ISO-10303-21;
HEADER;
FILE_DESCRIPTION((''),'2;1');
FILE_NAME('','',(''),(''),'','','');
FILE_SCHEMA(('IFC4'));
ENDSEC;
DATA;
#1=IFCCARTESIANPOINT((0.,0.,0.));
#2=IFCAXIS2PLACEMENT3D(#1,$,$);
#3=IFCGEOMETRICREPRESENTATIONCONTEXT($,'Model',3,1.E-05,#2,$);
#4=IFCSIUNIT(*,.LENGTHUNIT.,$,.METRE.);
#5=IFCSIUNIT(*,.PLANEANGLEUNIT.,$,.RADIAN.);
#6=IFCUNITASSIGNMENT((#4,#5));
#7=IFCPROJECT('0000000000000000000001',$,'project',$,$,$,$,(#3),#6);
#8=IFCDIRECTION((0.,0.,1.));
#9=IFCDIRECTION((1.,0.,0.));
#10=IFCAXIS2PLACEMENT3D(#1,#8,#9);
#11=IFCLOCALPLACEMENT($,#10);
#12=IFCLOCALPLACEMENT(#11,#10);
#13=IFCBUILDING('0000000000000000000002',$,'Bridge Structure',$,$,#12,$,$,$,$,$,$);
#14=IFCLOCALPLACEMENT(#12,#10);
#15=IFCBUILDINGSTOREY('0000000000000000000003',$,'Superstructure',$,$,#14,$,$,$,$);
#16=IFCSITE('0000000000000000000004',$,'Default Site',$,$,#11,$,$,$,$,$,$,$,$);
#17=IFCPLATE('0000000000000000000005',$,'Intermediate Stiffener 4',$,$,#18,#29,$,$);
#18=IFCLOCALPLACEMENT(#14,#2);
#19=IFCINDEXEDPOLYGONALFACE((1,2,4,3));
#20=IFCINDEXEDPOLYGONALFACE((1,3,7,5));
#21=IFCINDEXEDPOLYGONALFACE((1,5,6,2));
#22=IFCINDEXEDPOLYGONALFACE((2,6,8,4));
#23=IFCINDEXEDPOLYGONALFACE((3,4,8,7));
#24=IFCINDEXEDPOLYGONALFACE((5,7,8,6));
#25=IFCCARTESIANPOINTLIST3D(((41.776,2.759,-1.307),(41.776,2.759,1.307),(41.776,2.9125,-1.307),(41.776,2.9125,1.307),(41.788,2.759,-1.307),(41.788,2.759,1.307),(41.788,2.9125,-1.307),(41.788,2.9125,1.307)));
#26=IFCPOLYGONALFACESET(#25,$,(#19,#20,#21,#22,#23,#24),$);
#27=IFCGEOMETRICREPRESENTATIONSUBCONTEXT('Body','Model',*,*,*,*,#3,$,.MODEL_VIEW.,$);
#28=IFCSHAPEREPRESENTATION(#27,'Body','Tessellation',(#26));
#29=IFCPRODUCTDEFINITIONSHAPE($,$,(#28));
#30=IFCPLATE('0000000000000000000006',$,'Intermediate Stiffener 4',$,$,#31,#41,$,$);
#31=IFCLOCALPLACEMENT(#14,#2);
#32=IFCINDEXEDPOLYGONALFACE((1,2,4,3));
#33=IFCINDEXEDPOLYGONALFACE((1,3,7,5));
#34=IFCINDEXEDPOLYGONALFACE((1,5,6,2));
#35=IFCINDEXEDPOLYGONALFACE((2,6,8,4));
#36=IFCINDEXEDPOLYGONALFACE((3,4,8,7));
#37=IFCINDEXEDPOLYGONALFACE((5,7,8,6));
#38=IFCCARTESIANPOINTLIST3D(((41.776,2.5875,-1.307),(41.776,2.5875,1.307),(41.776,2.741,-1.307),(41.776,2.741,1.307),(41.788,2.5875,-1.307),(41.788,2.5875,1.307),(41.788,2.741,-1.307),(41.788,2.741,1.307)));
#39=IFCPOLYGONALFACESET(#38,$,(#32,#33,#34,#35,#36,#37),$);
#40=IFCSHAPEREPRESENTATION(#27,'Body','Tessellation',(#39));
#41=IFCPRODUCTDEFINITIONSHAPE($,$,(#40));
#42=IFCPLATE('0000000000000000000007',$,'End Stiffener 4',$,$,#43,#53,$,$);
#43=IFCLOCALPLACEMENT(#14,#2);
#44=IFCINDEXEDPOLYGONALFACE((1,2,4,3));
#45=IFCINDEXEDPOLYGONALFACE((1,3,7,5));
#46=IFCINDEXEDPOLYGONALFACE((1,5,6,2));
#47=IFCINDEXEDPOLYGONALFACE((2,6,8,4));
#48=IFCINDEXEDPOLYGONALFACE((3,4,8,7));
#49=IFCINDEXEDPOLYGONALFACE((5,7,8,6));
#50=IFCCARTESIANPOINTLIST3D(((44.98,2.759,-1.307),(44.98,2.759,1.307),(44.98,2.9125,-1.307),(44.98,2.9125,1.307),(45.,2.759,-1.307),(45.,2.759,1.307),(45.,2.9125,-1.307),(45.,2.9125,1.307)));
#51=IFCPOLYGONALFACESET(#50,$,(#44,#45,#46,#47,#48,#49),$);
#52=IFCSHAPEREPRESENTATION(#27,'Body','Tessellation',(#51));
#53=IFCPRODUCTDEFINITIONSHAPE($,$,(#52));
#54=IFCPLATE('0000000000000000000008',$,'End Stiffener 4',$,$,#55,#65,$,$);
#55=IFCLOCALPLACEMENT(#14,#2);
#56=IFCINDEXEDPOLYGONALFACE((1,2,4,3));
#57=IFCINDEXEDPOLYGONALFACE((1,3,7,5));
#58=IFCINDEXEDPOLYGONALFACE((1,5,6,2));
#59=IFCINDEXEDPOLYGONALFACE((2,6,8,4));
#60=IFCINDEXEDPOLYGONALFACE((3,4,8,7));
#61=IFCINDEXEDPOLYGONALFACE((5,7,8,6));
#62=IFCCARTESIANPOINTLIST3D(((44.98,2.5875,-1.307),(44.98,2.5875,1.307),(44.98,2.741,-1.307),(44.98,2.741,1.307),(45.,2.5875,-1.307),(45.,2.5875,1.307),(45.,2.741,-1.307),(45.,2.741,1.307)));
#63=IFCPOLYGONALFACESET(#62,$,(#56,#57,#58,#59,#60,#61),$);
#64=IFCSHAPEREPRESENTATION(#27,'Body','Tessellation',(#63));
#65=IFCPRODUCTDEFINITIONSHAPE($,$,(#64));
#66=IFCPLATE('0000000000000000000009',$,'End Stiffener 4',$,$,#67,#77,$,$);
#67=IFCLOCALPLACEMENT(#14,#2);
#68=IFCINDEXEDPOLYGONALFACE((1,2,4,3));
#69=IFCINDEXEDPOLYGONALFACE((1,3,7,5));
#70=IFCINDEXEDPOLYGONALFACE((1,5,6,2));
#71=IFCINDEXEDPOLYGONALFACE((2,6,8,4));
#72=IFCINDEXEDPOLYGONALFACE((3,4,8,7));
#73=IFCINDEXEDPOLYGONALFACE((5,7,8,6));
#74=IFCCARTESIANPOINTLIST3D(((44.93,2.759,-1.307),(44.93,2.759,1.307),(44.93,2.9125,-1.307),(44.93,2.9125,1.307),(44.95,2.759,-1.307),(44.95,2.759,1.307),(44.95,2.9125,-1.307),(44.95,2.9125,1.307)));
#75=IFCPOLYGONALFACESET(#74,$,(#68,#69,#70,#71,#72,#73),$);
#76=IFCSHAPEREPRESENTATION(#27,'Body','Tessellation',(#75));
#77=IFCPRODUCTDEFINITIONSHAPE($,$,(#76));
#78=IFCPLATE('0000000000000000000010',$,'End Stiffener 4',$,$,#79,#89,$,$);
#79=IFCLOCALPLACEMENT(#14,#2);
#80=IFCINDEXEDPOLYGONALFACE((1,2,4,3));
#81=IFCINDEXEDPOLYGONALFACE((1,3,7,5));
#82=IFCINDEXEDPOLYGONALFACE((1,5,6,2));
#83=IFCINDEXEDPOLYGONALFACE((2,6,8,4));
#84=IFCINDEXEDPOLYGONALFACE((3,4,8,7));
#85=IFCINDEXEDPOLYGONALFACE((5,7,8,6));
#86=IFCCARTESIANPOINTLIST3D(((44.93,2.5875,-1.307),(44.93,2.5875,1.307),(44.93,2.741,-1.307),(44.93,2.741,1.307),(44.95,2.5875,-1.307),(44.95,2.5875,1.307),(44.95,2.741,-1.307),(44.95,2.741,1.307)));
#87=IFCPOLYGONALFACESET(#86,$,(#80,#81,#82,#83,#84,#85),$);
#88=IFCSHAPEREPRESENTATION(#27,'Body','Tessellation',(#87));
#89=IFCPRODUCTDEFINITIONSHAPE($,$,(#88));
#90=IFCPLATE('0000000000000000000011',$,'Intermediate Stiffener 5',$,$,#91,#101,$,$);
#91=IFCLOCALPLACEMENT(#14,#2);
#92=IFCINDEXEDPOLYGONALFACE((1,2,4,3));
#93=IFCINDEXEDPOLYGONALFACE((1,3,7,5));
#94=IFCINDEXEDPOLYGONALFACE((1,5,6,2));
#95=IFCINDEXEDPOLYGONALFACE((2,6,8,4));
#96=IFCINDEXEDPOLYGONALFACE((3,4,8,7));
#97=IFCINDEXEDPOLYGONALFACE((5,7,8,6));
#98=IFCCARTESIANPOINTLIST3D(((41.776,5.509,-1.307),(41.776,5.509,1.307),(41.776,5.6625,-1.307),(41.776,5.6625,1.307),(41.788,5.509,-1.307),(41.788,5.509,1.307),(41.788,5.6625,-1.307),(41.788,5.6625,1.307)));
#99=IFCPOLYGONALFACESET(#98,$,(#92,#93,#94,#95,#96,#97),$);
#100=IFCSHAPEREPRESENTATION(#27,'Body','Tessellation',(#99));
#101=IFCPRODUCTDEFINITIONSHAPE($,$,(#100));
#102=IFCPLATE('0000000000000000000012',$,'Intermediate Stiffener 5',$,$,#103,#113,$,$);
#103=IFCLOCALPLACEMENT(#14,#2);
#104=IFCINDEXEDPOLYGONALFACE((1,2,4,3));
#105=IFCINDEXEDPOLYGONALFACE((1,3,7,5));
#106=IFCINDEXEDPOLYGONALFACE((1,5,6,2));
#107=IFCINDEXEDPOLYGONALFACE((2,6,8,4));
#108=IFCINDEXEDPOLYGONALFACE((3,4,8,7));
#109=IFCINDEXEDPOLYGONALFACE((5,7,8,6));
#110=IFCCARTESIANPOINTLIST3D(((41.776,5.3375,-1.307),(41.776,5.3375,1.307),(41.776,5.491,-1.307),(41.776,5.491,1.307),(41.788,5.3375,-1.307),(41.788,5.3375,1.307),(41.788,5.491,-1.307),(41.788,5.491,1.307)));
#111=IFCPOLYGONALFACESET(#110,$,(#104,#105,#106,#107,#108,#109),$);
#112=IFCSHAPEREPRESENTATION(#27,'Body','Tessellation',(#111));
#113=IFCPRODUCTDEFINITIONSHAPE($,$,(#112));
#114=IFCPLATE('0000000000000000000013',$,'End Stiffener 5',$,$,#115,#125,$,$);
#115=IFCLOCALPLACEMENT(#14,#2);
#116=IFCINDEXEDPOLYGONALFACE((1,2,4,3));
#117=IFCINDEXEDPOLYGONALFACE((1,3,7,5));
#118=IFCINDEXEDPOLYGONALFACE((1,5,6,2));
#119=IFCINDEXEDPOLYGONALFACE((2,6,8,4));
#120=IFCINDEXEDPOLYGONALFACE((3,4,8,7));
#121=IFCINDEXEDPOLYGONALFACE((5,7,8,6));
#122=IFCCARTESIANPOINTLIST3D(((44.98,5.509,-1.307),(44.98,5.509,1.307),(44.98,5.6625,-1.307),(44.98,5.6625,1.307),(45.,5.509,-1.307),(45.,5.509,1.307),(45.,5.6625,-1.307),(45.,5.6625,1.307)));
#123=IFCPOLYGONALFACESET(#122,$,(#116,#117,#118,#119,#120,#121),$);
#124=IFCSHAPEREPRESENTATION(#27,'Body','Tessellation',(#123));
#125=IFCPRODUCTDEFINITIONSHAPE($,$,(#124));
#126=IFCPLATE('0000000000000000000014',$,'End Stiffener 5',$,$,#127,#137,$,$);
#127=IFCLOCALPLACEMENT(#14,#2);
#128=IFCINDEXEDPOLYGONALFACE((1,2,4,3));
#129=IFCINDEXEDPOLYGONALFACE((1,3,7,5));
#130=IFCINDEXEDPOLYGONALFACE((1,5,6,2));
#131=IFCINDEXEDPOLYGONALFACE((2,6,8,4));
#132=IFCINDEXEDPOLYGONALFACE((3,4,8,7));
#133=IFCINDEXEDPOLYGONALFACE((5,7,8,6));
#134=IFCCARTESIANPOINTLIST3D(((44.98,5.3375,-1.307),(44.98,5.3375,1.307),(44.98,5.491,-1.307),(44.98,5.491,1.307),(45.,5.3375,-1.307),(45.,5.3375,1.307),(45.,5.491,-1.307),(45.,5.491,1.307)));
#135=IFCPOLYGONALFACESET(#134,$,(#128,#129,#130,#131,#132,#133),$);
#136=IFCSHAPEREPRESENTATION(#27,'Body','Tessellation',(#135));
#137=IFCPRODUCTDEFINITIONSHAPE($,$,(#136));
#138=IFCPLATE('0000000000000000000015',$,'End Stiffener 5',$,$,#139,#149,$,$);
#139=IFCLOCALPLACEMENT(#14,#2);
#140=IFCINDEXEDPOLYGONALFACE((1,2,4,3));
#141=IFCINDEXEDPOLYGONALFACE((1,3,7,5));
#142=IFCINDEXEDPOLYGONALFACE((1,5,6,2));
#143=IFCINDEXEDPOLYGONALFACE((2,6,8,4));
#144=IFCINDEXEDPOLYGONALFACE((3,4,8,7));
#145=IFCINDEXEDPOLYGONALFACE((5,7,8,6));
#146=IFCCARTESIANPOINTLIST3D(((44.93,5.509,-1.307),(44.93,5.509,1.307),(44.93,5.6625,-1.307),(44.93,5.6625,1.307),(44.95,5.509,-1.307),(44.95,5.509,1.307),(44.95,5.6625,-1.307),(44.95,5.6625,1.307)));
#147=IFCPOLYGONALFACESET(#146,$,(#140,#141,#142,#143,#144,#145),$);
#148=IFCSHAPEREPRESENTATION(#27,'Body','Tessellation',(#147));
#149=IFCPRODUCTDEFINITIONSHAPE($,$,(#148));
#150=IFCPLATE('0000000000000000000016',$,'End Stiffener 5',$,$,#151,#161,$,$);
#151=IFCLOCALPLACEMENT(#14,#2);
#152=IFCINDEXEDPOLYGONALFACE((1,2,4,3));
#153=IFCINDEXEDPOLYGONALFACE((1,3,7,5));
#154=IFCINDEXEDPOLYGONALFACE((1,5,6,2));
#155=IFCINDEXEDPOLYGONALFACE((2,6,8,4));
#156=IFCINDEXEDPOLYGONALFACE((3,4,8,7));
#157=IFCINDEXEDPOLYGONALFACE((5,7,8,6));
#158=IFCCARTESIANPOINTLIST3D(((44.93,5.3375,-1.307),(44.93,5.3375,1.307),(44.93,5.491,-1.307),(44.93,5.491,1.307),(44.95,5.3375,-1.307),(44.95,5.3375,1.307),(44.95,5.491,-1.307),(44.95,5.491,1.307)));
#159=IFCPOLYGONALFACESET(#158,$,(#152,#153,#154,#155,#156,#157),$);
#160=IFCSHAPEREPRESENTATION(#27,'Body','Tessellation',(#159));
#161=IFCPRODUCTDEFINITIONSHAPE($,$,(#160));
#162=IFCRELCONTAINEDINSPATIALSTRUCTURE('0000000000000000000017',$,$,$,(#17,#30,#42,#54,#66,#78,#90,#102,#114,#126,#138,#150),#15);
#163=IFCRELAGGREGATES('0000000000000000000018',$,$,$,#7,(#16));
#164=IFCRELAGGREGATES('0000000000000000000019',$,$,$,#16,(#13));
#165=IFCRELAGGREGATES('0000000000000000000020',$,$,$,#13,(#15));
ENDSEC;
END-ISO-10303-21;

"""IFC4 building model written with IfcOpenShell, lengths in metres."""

from ifc_helpers import new_model, si_unit, frame, origin, origin_with_axes, origin_2d_with_axis, place, context, subcontext, project, spatial, rectangle, extrude, element, save


model = new_model("IFC4")

# Units and contexts
model_context = context("Model", 3, precision=1e-05, world=origin())
body_context = subcontext(model_context, "Body", "Model", "MODEL_VIEW")
ifc_project = project(units=[si_unit("LENGTHUNIT", "METRE"), si_unit("PLANEANGLEUNIT", "RADIAN")], contexts=[model_context])

# Site, building, storey
site_placement = place(None, origin_with_axes())
site = spatial("IfcSite", under=ifc_project, at=site_placement, Name="Default Site")
building_placement = place(site_placement, origin_with_axes())
building = spatial("IfcBuilding", under=site, at=building_placement, Name="Bridge Structure")
storey_placement = place(building_placement, origin_with_axes())
storey = spatial("IfcBuildingStorey", under=building, at=storey_placement, Name="Superstructure")

# Plates
for number, where, z_axis, x_axis, name in (
    (1, (41.782, 2.8357, -1.307), (0.0, 0.0, 1.0), (1.0, 0.0, 0.0), "Intermediate Stiffener 4"),
    (2, (41.782, 2.6643, -1.307), (0.0, 0.0, 1.0), (1.0, 0.0, 0.0), "Intermediate Stiffener 4"),
):
    element("IfcPlate", number, at=place(storey_placement, frame(where, z_axis=z_axis, x_axis=x_axis)), inside=storey, Name=name, context=body_context, shape_type="SweptSolid", body=[
        extrude(rectangle(XDim=0.012, YDim=0.1535, at=origin_2d_with_axis()), origin_with_axes(), (0.0, 0.0, 1.0), 2.614),
    ])
for number, where, z_axis, x_axis, name in (
    (3, (44.99, 2.8357, -1.307), (0.0, 0.0, 1.0), (1.0, 0.0, 0.0), "End Stiffener 4"),
    (4, (44.99, 2.6643, -1.307), (0.0, 0.0, 1.0), (1.0, 0.0, 0.0), "End Stiffener 4"),
    (5, (44.94, 2.8357, -1.307), (0.0, 0.0, 1.0), (1.0, 0.0, 0.0), "End Stiffener 4"),
    (6, (44.94, 2.6643, -1.307), (0.0, 0.0, 1.0), (1.0, 0.0, 0.0), "End Stiffener 4"),
):
    element("IfcPlate", number, at=place(storey_placement, frame(where, z_axis=z_axis, x_axis=x_axis)), inside=storey, Name=name, context=body_context, shape_type="SweptSolid", body=[
        extrude(rectangle(XDim=0.02, YDim=0.1535, at=origin_2d_with_axis()), origin_with_axes(), (0.0, 0.0, 1.0), 2.614),
    ])
for number, where, z_axis, x_axis, name in (
    (7, (41.782, 5.5857, -1.307), (0.0, 0.0, 1.0), (1.0, 0.0, 0.0), "Intermediate Stiffener 5"),
    (8, (41.782, 5.4143, -1.307), (0.0, 0.0, 1.0), (1.0, 0.0, 0.0), "Intermediate Stiffener 5"),
):
    element("IfcPlate", number, at=place(storey_placement, frame(where, z_axis=z_axis, x_axis=x_axis)), inside=storey, Name=name, context=body_context, shape_type="SweptSolid", body=[
        extrude(rectangle(XDim=0.012, YDim=0.1535, at=origin_2d_with_axis()), origin_with_axes(), (0.0, 0.0, 1.0), 2.614),
    ])
for number, where, z_axis, x_axis, name in (
    (9, (44.99, 5.5857, -1.307), (0.0, 0.0, 1.0), (1.0, 0.0, 0.0), "End Stiffener 5"),
    (10, (44.99, 5.4143, -1.307), (0.0, 0.0, 1.0), (1.0, 0.0, 0.0), "End Stiffener 5"),
    (11, (44.94, 5.5857, -1.307), (0.0, 0.0, 1.0), (1.0, 0.0, 0.0), "End Stiffener 5"),
    (12, (44.94, 5.4143, -1.307), (0.0, 0.0, 1.0), (1.0, 0.0, 0.0), "End Stiffener 5"),
):
    element("IfcPlate", number, at=place(storey_placement, frame(where, z_axis=z_axis, x_axis=x_axis)), inside=storey, Name=name, context=body_context, shape_type="SweptSolid", body=[
        extrude(rectangle(XDim=0.02, YDim=0.1535, at=origin_2d_with_axis()), origin_with_axes(), (0.0, 0.0, 1.0), 2.614),
    ])

save(model, "model.ifc")
